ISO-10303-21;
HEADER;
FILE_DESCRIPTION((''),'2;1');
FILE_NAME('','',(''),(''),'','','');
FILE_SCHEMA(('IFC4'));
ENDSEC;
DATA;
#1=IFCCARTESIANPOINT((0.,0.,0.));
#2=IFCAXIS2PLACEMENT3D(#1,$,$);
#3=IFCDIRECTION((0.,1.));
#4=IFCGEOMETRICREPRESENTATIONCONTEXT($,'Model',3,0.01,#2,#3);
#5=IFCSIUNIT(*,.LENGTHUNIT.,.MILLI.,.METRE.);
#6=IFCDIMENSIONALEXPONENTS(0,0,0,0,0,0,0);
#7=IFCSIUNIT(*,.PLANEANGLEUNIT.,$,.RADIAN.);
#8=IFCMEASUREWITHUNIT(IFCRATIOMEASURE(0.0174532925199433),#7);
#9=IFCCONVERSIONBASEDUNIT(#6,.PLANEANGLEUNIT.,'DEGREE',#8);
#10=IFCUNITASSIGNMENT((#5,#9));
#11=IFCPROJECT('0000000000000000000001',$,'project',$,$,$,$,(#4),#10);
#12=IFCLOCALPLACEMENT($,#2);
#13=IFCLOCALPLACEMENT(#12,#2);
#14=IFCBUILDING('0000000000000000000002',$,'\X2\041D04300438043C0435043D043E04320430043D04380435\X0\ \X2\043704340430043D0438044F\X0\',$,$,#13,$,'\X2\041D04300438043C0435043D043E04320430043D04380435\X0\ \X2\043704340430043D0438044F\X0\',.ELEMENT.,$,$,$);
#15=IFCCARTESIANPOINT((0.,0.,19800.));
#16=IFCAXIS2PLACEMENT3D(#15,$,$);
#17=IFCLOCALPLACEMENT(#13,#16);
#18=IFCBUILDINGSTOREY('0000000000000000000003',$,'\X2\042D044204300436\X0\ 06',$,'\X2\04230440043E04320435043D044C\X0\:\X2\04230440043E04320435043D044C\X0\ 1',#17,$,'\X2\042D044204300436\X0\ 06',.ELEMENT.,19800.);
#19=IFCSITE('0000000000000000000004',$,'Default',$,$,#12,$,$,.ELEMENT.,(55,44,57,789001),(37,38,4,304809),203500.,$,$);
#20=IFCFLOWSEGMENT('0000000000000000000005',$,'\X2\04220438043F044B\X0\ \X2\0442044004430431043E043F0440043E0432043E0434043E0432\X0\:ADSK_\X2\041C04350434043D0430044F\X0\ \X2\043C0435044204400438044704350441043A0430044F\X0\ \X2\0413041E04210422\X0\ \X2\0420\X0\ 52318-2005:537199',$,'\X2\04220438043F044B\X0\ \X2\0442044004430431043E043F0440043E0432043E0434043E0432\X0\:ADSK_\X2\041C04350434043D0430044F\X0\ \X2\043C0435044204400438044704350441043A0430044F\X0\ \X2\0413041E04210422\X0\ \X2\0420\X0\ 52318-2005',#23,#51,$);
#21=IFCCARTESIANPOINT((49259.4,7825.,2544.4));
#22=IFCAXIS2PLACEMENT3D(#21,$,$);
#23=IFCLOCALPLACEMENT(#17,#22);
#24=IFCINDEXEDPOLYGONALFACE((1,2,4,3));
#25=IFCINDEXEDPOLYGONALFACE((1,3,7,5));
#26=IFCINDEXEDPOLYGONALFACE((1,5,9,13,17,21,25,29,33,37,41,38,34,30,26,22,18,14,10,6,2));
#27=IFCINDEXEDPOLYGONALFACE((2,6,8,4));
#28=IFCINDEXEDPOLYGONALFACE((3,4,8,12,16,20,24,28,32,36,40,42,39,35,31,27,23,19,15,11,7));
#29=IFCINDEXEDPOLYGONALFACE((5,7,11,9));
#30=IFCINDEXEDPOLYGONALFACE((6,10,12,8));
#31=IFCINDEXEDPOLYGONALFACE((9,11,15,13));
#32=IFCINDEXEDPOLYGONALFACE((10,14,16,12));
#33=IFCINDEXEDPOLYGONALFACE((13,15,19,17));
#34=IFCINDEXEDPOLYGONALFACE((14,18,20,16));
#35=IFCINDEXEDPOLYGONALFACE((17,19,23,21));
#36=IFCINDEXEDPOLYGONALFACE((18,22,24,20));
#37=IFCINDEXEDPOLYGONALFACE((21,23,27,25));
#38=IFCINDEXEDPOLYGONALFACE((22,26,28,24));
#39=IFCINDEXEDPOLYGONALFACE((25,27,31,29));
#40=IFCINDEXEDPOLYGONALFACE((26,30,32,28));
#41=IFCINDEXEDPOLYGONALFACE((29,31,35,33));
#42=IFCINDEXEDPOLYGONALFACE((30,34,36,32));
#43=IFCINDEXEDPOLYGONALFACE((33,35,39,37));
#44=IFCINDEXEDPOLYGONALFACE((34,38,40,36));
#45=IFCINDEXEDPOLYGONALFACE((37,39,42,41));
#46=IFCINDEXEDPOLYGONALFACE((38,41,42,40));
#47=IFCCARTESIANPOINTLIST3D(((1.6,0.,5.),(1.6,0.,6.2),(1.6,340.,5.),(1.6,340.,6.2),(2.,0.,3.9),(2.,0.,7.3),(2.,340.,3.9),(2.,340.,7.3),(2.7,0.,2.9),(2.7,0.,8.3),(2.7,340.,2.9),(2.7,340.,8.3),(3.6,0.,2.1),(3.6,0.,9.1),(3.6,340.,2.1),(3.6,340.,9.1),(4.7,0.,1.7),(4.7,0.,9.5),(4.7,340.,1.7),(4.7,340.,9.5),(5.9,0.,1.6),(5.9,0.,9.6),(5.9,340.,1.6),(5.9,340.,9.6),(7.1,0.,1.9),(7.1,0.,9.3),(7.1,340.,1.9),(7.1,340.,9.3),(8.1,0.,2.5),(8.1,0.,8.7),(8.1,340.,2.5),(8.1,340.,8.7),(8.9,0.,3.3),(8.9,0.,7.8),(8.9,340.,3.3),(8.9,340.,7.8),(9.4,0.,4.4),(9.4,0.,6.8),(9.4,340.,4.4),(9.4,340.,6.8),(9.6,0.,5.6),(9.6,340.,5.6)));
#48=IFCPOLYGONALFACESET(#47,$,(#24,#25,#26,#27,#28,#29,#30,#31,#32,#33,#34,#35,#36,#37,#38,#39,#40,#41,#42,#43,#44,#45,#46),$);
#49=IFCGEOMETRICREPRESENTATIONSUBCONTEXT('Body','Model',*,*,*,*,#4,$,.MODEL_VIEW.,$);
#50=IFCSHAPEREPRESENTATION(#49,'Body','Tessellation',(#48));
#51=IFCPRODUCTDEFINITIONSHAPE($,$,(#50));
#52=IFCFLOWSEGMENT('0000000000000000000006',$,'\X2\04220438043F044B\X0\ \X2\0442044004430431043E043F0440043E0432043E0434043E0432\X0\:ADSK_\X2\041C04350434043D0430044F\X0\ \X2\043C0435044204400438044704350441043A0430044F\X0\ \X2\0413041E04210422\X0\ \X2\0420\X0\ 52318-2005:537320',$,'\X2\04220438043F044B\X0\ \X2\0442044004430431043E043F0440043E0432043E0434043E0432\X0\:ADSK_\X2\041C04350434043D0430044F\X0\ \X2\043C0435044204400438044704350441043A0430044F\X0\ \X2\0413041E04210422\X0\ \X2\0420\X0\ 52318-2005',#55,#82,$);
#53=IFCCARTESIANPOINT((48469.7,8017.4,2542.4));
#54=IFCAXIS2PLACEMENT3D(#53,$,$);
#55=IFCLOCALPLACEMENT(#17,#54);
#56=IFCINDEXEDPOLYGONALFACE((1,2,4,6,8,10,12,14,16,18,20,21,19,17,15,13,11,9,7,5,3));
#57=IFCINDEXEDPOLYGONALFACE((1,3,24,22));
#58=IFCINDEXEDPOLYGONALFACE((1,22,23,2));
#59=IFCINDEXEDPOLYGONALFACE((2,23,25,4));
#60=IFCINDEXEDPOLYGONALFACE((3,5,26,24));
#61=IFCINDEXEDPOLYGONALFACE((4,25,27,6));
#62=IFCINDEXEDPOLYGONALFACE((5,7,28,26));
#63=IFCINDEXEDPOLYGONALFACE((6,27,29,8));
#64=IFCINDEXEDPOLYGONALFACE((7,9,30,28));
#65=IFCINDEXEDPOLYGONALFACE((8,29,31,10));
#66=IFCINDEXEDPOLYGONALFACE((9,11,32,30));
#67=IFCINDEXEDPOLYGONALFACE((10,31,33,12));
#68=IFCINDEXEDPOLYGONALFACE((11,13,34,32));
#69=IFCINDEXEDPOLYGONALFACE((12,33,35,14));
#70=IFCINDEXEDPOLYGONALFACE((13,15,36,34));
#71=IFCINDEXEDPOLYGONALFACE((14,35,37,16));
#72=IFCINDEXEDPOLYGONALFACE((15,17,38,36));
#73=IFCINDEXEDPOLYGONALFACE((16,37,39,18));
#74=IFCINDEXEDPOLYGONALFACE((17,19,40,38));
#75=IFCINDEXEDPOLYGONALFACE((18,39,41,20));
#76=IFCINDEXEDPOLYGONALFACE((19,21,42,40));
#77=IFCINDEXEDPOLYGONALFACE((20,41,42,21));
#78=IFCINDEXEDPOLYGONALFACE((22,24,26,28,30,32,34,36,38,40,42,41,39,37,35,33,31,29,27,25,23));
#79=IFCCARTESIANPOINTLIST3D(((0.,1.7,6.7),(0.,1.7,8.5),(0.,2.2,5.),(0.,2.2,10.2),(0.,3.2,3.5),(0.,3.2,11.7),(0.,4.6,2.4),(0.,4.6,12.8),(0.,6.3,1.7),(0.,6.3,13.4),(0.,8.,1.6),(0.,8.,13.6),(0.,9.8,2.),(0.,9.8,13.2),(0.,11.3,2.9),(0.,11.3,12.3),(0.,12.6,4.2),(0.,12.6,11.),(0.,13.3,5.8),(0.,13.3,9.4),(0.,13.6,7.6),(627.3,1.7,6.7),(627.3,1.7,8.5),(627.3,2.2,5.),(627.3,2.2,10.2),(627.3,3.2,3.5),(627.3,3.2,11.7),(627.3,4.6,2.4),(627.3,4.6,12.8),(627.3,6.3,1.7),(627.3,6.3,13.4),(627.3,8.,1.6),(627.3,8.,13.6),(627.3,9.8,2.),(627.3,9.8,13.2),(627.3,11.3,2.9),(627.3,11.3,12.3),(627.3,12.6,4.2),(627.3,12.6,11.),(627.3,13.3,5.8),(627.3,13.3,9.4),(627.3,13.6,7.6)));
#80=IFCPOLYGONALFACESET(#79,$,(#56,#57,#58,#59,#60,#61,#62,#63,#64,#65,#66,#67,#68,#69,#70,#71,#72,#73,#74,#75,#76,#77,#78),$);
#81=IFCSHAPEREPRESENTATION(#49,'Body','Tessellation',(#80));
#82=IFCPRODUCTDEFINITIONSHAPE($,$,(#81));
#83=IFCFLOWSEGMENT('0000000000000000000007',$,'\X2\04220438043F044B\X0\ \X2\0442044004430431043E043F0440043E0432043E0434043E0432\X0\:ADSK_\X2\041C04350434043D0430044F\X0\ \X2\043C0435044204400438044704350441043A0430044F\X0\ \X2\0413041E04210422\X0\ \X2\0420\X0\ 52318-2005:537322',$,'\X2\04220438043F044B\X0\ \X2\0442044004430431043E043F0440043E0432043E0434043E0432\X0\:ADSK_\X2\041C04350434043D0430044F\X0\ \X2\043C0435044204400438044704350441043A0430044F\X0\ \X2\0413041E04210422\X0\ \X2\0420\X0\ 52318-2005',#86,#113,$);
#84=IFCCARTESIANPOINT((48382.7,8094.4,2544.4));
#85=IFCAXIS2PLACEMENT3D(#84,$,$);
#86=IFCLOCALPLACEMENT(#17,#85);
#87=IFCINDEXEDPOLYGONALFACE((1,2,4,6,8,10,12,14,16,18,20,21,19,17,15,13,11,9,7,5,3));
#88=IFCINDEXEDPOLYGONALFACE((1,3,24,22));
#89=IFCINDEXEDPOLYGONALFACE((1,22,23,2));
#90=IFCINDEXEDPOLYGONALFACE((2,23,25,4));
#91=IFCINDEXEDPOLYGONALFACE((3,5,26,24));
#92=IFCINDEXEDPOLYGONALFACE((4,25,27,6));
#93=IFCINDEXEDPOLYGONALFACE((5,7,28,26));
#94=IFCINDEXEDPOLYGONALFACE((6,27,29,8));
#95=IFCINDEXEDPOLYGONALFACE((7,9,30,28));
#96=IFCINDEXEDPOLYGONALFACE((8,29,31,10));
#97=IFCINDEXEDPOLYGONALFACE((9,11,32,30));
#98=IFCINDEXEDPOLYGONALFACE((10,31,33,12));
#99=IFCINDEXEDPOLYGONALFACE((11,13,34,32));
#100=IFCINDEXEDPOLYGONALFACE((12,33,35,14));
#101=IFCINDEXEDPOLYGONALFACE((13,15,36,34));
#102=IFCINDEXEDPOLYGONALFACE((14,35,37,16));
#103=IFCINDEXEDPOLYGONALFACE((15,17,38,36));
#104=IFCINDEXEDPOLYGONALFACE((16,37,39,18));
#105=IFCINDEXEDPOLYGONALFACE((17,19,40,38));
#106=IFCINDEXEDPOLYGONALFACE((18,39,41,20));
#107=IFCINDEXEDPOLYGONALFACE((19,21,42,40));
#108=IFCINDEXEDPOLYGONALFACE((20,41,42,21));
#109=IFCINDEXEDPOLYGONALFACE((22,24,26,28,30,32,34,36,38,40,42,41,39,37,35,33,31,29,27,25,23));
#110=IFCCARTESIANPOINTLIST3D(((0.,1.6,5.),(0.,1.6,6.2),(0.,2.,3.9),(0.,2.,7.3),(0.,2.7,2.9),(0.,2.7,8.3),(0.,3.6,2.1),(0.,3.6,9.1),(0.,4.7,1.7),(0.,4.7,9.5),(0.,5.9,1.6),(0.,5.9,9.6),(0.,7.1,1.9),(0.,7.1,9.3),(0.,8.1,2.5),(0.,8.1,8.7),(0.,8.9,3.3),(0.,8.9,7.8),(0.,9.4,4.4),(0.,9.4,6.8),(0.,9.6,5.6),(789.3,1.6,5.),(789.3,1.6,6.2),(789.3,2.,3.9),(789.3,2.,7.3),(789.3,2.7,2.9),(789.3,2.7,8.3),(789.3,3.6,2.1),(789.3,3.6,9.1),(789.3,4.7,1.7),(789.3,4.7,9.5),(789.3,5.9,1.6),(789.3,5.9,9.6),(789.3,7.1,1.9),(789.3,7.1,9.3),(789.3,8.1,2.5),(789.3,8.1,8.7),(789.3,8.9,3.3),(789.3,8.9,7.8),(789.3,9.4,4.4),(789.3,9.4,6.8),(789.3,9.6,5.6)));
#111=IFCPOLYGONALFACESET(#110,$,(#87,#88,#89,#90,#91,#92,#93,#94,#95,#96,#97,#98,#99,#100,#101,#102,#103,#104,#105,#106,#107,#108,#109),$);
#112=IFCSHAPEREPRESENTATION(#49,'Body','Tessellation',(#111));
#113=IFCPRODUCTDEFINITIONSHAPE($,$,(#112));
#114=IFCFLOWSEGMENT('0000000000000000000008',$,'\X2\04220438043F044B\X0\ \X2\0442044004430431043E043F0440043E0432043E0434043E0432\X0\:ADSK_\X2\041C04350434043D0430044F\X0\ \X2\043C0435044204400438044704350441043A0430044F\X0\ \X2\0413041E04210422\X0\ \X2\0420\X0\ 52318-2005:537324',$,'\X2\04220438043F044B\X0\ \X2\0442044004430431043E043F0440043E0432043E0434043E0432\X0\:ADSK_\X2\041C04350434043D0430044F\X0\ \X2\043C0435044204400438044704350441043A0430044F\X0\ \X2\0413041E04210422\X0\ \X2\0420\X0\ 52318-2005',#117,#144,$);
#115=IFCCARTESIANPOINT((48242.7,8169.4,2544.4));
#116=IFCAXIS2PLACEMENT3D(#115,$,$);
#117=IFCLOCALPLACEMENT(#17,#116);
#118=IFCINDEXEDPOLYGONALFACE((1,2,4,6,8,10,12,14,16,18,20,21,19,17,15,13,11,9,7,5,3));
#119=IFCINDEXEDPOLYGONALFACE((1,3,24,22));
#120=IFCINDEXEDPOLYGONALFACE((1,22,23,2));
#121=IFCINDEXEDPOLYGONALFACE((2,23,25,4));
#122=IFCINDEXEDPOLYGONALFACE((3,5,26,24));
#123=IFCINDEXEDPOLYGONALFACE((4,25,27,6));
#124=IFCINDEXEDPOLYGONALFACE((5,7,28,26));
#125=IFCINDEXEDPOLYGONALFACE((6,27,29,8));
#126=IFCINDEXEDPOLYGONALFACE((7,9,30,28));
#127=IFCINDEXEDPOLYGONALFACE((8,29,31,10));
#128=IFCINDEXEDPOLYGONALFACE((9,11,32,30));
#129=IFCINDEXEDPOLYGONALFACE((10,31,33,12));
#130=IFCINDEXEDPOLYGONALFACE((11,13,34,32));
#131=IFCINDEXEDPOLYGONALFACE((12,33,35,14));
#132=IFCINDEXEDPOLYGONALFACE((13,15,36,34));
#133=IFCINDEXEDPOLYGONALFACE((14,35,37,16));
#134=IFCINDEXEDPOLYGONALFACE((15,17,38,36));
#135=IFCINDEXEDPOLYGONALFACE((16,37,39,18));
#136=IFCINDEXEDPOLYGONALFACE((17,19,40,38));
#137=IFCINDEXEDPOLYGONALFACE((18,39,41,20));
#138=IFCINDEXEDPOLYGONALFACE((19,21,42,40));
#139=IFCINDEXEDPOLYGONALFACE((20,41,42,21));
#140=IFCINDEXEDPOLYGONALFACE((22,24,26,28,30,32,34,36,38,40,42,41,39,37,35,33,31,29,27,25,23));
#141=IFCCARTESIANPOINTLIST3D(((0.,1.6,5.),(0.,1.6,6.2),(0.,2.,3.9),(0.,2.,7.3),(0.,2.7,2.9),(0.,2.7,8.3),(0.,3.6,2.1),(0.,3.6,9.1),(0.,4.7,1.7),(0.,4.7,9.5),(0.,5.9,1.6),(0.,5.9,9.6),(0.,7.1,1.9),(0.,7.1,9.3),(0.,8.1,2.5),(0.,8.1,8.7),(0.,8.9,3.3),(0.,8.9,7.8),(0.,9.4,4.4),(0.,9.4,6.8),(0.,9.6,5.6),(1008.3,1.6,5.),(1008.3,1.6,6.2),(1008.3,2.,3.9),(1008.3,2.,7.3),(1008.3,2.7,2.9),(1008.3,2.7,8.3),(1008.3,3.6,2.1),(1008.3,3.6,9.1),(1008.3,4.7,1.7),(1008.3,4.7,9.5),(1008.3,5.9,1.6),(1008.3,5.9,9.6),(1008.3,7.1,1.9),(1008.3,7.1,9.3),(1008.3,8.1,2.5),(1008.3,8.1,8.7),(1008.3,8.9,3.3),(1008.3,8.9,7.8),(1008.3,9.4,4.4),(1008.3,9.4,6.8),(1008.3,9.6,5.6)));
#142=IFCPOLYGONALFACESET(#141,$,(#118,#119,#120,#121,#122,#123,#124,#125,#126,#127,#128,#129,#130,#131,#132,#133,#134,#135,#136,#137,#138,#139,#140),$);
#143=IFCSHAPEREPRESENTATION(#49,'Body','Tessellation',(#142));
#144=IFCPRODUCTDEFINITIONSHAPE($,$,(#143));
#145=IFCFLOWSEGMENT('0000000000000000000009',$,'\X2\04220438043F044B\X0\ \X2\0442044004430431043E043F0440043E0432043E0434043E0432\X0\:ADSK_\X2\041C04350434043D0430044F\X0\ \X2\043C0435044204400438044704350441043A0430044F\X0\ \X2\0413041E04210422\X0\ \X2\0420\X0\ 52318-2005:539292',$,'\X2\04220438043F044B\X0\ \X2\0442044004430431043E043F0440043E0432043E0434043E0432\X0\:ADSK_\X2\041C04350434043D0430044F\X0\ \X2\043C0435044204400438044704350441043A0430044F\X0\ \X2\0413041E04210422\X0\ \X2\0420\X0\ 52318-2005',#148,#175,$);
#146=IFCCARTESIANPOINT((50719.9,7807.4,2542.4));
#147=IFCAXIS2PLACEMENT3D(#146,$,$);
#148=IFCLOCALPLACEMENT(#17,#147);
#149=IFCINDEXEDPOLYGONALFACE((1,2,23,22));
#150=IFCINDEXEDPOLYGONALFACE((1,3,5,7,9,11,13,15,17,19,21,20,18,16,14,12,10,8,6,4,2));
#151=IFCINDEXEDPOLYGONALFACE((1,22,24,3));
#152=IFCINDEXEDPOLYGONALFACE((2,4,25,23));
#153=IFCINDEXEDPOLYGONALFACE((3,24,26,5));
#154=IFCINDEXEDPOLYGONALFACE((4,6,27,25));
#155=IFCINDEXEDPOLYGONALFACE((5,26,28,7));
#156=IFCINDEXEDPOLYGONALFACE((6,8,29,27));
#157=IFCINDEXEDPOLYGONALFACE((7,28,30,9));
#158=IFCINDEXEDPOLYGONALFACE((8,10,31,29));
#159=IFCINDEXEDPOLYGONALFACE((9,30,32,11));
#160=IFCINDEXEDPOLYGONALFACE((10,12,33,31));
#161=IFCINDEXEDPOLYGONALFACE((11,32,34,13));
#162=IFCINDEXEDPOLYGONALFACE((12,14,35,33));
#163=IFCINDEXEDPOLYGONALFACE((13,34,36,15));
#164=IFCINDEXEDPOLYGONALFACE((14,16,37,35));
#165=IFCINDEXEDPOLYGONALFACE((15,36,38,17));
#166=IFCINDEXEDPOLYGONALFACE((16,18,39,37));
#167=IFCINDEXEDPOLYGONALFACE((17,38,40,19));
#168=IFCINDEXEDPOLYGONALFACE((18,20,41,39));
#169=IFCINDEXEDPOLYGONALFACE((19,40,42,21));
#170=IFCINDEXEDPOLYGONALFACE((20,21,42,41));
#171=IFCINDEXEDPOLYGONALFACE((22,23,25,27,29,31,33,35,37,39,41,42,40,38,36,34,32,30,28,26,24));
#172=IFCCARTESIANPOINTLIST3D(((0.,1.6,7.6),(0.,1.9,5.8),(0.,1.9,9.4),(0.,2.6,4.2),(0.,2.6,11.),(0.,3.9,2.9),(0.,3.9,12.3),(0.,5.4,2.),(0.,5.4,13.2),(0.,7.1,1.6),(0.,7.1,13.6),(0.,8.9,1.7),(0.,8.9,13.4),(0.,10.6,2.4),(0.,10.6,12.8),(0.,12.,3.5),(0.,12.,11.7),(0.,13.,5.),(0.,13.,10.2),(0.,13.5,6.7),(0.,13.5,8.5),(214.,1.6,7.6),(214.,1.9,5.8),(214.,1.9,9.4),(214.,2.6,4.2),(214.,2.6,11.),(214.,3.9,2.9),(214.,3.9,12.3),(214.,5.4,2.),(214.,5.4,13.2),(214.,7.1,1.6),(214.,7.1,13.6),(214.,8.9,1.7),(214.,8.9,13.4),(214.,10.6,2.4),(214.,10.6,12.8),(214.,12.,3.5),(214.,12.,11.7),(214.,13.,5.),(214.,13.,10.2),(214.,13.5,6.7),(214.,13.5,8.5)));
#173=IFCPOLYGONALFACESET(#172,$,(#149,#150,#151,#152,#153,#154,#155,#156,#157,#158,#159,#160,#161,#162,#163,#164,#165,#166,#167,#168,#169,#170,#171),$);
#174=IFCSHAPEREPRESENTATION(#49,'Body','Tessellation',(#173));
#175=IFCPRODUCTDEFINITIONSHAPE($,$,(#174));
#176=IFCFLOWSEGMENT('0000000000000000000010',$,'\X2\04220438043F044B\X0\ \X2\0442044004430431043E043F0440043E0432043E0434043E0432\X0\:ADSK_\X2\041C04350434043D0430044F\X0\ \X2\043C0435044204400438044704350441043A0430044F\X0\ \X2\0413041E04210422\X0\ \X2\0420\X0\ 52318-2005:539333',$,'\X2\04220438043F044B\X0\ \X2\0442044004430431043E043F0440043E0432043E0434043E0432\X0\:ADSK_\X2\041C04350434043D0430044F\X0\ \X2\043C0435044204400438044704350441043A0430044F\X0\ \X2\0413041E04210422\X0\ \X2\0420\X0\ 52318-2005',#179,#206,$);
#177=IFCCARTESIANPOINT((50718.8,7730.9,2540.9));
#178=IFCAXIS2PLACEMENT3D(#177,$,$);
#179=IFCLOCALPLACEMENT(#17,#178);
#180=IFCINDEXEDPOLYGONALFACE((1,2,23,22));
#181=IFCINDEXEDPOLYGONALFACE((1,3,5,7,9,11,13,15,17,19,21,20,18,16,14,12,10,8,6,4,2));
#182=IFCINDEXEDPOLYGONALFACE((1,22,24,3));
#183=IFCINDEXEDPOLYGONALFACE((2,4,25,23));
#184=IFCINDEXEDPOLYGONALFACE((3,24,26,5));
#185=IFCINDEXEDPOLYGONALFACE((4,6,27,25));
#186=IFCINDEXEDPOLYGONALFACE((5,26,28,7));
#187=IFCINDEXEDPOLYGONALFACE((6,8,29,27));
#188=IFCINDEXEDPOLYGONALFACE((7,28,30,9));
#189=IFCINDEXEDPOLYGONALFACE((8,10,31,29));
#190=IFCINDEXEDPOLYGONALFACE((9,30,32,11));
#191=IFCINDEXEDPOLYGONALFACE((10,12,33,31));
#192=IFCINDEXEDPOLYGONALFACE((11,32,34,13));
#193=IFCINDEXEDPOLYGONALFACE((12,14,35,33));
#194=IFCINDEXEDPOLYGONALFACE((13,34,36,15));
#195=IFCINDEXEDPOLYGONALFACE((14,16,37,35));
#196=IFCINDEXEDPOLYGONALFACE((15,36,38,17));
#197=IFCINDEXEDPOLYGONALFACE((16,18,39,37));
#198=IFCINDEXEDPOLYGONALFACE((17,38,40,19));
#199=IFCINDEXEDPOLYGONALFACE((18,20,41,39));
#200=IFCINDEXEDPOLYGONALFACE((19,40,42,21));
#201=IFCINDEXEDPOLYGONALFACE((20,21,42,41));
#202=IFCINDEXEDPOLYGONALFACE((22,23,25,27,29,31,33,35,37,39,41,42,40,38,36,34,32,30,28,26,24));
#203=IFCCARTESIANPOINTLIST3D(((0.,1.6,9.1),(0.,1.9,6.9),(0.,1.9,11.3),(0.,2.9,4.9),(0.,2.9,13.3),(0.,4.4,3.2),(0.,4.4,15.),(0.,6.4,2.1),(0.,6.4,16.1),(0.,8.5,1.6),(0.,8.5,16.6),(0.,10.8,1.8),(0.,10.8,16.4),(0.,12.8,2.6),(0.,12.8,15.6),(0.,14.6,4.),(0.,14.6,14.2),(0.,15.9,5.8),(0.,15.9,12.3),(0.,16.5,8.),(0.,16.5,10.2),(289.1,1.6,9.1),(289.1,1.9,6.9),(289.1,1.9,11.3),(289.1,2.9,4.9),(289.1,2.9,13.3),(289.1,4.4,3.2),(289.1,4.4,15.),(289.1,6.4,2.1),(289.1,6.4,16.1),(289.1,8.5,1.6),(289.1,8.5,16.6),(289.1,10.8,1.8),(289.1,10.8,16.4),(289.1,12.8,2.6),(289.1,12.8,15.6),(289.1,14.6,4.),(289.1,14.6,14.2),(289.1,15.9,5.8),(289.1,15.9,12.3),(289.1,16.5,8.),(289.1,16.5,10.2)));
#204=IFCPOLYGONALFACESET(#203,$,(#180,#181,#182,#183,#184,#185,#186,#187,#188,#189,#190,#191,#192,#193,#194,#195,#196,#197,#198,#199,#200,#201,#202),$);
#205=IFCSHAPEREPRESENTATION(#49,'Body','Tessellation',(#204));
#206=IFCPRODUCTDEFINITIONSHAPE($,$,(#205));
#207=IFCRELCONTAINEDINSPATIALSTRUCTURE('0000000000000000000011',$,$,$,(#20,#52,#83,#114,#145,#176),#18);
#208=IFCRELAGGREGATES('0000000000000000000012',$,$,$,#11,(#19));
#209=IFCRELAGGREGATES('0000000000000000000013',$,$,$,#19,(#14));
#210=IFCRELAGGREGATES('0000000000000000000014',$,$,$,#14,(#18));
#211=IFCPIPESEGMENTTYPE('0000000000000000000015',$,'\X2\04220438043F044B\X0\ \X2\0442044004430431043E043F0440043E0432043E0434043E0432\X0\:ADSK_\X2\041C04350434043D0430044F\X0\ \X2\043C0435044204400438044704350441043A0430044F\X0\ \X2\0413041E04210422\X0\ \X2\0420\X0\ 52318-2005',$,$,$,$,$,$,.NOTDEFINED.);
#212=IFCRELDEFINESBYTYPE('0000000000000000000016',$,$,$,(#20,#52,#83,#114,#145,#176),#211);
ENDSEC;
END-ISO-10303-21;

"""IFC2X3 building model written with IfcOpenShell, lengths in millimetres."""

from ifc_helpers import new_model, entity, si_unit, converted_unit, direction, frame, frame_2d, origin, origin_2d_with_axis, place, context, subcontext, project, spatial, circle, extrude, type_object, element, save


model = new_model("IFC2X3")

# Units and contexts
model_context = context("Model", 3, precision=0.01, world=origin(), true_north=direction((0.0, 1.0)))
body_context = subcontext(model_context, "Body", "Model", "MODEL_VIEW")
ifc_project = project(units=[si_unit("LENGTHUNIT", "METRE", prefix="MILLI"), converted_unit("PLANEANGLEUNIT", "DEGREE", entity("IfcRatioMeasure", 0.0174532925199433), si_unit("PLANEANGLEUNIT", "RADIAN"), dimensions=[0, 0, 0, 0, 0, 0, 0])], contexts=[model_context])

# Site, building, storey
site_placement = place(None, frame((0.0, 0.0, 0.0)))
site = spatial("IfcSite", under=ifc_project, at=site_placement, Name="Default", CompositionType="ELEMENT", RefLatitude=(55, 44, 57, 789001), RefLongitude=(37, 38, 4, 304809), RefElevation=203500.0)
building_placement = place(site_placement, origin())
building = spatial("IfcBuilding", under=site, at=building_placement, Name="Наименование здания", LongName="Наименование здания", CompositionType="ELEMENT")
storey_placement = place(building_placement, frame((0.0, 0.0, 19800.0)))
storey = spatial("IfcBuildingStorey", under=building, at=storey_placement, Name="Этаж 06", ObjectType="Уровень:Уровень 1", LongName="Этаж 06", CompositionType="ELEMENT", Elevation=19800.0)

# Flow segments
pipe_segment_type = type_object("IfcPipeSegmentType", Name="Типы трубопроводов:ADSK_Медная метрическая ГОСТ Р 52318-2005", PredefinedType="NOTDEFINED")
for number, where, name in (
    (1, (49259.4, 7825.0, 2544.4), "Типы трубопроводов:ADSK_Медная метрическая ГОСТ Р 52318-2005:537199"),
):
    element("IfcFlowSegment", number, at=place(storey_placement, frame(where)), inside=storey, type_object=pipe_segment_type, Name=name, ObjectType="Типы трубопроводов:ADSK_Медная метрическая ГОСТ Р 52318-2005", context=body_context, shape_type="SweptSolid", body=[
        extrude(circle(Radius=4.0, at=origin_2d_with_axis()), frame((5.6, 0.0, 5.6), z_axis=(0.0, 1.0, 0.0), x_axis=(1.0, 0.0, 0.0)), (0.0, 0.0, 1.0), 340.0),
    ])
flow_segment_1_placement = place(storey_placement, frame((48469.7, 8017.4, 2542.4)))
element("IfcFlowSegment", 2, at=flow_segment_1_placement, inside=storey, type_object=pipe_segment_type, Name="Типы трубопроводов:ADSK_Медная метрическая ГОСТ Р 52318-2005:537320", ObjectType="Типы трубопроводов:ADSK_Медная метрическая ГОСТ Р 52318-2005", context=body_context, shape_type="SweptSolid", body=[
    extrude(circle(Radius=6.0, at=origin_2d_with_axis()), frame((0.0, 7.6, 7.6), z_axis=(1.0, 0.0, 0.0), x_axis=(0.0, 1.0, 0.0)), (0.0, 0.0, 1.0), 627.3),
])
flow_segment_2_placement = place(storey_placement, frame((48382.7, 8094.4, 2544.4)))
element("IfcFlowSegment", 3, at=flow_segment_2_placement, inside=storey, type_object=pipe_segment_type, Name="Типы трубопроводов:ADSK_Медная метрическая ГОСТ Р 52318-2005:537322", ObjectType="Типы трубопроводов:ADSK_Медная метрическая ГОСТ Р 52318-2005", context=body_context, shape_type="SweptSolid", body=[
    extrude(circle(Radius=4.0, at=frame_2d((0.0, 0.0), x_axis=(1.0, 0.0))), frame((0.0, 5.6, 5.6), z_axis=(1.0, 0.0, 0.0), x_axis=(0.0, 1.0, 0.0)), (0.0, 0.0, 1.0), 789.3),
])
flow_segment_3_placement = place(storey_placement, frame((48242.7, 8169.4, 2544.4)))
element("IfcFlowSegment", 4, at=flow_segment_3_placement, inside=storey, type_object=pipe_segment_type, Name="Типы трубопроводов:ADSK_Медная метрическая ГОСТ Р 52318-2005:537324", ObjectType="Типы трубопроводов:ADSK_Медная метрическая ГОСТ Р 52318-2005", context=body_context, shape_type="SweptSolid", body=[
    extrude(circle(Radius=4.0, at=frame_2d((0.0, 0.0), x_axis=(1.0, 0.0))), frame((0.0, 5.6, 5.6), z_axis=(1.0, 0.0, 0.0), x_axis=(0.0, 1.0, 0.0)), (0.0, 0.0, 1.0), 1008.3),
])
flow_segment_4_placement = place(storey_placement, frame((50719.9, 7807.4, 2542.4)))
element("IfcFlowSegment", 5, at=flow_segment_4_placement, inside=storey, type_object=pipe_segment_type, Name="Типы трубопроводов:ADSK_Медная метрическая ГОСТ Р 52318-2005:539292", ObjectType="Типы трубопроводов:ADSK_Медная метрическая ГОСТ Р 52318-2005", context=body_context, shape_type="SweptSolid", body=[
    extrude(circle(Radius=6.0, at=frame_2d((0.0, 0.0), x_axis=(1.0, 0.0))), frame((0.0, 7.6, 7.6), z_axis=(1.0, 0.0, 0.0), x_axis=(0.0, -1.0, 0.0)), (0.0, 0.0, 1.0), 214.0),
])
flow_segment_5_placement = place(storey_placement, frame((50718.8, 7730.9, 2540.9)))
element("IfcFlowSegment", 6, at=flow_segment_5_placement, inside=storey, type_object=pipe_segment_type, Name="Типы трубопроводов:ADSK_Медная метрическая ГОСТ Р 52318-2005:539333", ObjectType="Типы трубопроводов:ADSK_Медная метрическая ГОСТ Р 52318-2005", context=body_context, shape_type="SweptSolid", body=[
    extrude(circle(Radius=7.5, at=origin_2d_with_axis()), frame((0.0, 9.1, 9.1), z_axis=(1.0, 0.0, 0.0), x_axis=(0.0, -1.0, 0.0)), (0.0, 0.0, 1.0), 289.1),
])

save(model, "model.ifc")
